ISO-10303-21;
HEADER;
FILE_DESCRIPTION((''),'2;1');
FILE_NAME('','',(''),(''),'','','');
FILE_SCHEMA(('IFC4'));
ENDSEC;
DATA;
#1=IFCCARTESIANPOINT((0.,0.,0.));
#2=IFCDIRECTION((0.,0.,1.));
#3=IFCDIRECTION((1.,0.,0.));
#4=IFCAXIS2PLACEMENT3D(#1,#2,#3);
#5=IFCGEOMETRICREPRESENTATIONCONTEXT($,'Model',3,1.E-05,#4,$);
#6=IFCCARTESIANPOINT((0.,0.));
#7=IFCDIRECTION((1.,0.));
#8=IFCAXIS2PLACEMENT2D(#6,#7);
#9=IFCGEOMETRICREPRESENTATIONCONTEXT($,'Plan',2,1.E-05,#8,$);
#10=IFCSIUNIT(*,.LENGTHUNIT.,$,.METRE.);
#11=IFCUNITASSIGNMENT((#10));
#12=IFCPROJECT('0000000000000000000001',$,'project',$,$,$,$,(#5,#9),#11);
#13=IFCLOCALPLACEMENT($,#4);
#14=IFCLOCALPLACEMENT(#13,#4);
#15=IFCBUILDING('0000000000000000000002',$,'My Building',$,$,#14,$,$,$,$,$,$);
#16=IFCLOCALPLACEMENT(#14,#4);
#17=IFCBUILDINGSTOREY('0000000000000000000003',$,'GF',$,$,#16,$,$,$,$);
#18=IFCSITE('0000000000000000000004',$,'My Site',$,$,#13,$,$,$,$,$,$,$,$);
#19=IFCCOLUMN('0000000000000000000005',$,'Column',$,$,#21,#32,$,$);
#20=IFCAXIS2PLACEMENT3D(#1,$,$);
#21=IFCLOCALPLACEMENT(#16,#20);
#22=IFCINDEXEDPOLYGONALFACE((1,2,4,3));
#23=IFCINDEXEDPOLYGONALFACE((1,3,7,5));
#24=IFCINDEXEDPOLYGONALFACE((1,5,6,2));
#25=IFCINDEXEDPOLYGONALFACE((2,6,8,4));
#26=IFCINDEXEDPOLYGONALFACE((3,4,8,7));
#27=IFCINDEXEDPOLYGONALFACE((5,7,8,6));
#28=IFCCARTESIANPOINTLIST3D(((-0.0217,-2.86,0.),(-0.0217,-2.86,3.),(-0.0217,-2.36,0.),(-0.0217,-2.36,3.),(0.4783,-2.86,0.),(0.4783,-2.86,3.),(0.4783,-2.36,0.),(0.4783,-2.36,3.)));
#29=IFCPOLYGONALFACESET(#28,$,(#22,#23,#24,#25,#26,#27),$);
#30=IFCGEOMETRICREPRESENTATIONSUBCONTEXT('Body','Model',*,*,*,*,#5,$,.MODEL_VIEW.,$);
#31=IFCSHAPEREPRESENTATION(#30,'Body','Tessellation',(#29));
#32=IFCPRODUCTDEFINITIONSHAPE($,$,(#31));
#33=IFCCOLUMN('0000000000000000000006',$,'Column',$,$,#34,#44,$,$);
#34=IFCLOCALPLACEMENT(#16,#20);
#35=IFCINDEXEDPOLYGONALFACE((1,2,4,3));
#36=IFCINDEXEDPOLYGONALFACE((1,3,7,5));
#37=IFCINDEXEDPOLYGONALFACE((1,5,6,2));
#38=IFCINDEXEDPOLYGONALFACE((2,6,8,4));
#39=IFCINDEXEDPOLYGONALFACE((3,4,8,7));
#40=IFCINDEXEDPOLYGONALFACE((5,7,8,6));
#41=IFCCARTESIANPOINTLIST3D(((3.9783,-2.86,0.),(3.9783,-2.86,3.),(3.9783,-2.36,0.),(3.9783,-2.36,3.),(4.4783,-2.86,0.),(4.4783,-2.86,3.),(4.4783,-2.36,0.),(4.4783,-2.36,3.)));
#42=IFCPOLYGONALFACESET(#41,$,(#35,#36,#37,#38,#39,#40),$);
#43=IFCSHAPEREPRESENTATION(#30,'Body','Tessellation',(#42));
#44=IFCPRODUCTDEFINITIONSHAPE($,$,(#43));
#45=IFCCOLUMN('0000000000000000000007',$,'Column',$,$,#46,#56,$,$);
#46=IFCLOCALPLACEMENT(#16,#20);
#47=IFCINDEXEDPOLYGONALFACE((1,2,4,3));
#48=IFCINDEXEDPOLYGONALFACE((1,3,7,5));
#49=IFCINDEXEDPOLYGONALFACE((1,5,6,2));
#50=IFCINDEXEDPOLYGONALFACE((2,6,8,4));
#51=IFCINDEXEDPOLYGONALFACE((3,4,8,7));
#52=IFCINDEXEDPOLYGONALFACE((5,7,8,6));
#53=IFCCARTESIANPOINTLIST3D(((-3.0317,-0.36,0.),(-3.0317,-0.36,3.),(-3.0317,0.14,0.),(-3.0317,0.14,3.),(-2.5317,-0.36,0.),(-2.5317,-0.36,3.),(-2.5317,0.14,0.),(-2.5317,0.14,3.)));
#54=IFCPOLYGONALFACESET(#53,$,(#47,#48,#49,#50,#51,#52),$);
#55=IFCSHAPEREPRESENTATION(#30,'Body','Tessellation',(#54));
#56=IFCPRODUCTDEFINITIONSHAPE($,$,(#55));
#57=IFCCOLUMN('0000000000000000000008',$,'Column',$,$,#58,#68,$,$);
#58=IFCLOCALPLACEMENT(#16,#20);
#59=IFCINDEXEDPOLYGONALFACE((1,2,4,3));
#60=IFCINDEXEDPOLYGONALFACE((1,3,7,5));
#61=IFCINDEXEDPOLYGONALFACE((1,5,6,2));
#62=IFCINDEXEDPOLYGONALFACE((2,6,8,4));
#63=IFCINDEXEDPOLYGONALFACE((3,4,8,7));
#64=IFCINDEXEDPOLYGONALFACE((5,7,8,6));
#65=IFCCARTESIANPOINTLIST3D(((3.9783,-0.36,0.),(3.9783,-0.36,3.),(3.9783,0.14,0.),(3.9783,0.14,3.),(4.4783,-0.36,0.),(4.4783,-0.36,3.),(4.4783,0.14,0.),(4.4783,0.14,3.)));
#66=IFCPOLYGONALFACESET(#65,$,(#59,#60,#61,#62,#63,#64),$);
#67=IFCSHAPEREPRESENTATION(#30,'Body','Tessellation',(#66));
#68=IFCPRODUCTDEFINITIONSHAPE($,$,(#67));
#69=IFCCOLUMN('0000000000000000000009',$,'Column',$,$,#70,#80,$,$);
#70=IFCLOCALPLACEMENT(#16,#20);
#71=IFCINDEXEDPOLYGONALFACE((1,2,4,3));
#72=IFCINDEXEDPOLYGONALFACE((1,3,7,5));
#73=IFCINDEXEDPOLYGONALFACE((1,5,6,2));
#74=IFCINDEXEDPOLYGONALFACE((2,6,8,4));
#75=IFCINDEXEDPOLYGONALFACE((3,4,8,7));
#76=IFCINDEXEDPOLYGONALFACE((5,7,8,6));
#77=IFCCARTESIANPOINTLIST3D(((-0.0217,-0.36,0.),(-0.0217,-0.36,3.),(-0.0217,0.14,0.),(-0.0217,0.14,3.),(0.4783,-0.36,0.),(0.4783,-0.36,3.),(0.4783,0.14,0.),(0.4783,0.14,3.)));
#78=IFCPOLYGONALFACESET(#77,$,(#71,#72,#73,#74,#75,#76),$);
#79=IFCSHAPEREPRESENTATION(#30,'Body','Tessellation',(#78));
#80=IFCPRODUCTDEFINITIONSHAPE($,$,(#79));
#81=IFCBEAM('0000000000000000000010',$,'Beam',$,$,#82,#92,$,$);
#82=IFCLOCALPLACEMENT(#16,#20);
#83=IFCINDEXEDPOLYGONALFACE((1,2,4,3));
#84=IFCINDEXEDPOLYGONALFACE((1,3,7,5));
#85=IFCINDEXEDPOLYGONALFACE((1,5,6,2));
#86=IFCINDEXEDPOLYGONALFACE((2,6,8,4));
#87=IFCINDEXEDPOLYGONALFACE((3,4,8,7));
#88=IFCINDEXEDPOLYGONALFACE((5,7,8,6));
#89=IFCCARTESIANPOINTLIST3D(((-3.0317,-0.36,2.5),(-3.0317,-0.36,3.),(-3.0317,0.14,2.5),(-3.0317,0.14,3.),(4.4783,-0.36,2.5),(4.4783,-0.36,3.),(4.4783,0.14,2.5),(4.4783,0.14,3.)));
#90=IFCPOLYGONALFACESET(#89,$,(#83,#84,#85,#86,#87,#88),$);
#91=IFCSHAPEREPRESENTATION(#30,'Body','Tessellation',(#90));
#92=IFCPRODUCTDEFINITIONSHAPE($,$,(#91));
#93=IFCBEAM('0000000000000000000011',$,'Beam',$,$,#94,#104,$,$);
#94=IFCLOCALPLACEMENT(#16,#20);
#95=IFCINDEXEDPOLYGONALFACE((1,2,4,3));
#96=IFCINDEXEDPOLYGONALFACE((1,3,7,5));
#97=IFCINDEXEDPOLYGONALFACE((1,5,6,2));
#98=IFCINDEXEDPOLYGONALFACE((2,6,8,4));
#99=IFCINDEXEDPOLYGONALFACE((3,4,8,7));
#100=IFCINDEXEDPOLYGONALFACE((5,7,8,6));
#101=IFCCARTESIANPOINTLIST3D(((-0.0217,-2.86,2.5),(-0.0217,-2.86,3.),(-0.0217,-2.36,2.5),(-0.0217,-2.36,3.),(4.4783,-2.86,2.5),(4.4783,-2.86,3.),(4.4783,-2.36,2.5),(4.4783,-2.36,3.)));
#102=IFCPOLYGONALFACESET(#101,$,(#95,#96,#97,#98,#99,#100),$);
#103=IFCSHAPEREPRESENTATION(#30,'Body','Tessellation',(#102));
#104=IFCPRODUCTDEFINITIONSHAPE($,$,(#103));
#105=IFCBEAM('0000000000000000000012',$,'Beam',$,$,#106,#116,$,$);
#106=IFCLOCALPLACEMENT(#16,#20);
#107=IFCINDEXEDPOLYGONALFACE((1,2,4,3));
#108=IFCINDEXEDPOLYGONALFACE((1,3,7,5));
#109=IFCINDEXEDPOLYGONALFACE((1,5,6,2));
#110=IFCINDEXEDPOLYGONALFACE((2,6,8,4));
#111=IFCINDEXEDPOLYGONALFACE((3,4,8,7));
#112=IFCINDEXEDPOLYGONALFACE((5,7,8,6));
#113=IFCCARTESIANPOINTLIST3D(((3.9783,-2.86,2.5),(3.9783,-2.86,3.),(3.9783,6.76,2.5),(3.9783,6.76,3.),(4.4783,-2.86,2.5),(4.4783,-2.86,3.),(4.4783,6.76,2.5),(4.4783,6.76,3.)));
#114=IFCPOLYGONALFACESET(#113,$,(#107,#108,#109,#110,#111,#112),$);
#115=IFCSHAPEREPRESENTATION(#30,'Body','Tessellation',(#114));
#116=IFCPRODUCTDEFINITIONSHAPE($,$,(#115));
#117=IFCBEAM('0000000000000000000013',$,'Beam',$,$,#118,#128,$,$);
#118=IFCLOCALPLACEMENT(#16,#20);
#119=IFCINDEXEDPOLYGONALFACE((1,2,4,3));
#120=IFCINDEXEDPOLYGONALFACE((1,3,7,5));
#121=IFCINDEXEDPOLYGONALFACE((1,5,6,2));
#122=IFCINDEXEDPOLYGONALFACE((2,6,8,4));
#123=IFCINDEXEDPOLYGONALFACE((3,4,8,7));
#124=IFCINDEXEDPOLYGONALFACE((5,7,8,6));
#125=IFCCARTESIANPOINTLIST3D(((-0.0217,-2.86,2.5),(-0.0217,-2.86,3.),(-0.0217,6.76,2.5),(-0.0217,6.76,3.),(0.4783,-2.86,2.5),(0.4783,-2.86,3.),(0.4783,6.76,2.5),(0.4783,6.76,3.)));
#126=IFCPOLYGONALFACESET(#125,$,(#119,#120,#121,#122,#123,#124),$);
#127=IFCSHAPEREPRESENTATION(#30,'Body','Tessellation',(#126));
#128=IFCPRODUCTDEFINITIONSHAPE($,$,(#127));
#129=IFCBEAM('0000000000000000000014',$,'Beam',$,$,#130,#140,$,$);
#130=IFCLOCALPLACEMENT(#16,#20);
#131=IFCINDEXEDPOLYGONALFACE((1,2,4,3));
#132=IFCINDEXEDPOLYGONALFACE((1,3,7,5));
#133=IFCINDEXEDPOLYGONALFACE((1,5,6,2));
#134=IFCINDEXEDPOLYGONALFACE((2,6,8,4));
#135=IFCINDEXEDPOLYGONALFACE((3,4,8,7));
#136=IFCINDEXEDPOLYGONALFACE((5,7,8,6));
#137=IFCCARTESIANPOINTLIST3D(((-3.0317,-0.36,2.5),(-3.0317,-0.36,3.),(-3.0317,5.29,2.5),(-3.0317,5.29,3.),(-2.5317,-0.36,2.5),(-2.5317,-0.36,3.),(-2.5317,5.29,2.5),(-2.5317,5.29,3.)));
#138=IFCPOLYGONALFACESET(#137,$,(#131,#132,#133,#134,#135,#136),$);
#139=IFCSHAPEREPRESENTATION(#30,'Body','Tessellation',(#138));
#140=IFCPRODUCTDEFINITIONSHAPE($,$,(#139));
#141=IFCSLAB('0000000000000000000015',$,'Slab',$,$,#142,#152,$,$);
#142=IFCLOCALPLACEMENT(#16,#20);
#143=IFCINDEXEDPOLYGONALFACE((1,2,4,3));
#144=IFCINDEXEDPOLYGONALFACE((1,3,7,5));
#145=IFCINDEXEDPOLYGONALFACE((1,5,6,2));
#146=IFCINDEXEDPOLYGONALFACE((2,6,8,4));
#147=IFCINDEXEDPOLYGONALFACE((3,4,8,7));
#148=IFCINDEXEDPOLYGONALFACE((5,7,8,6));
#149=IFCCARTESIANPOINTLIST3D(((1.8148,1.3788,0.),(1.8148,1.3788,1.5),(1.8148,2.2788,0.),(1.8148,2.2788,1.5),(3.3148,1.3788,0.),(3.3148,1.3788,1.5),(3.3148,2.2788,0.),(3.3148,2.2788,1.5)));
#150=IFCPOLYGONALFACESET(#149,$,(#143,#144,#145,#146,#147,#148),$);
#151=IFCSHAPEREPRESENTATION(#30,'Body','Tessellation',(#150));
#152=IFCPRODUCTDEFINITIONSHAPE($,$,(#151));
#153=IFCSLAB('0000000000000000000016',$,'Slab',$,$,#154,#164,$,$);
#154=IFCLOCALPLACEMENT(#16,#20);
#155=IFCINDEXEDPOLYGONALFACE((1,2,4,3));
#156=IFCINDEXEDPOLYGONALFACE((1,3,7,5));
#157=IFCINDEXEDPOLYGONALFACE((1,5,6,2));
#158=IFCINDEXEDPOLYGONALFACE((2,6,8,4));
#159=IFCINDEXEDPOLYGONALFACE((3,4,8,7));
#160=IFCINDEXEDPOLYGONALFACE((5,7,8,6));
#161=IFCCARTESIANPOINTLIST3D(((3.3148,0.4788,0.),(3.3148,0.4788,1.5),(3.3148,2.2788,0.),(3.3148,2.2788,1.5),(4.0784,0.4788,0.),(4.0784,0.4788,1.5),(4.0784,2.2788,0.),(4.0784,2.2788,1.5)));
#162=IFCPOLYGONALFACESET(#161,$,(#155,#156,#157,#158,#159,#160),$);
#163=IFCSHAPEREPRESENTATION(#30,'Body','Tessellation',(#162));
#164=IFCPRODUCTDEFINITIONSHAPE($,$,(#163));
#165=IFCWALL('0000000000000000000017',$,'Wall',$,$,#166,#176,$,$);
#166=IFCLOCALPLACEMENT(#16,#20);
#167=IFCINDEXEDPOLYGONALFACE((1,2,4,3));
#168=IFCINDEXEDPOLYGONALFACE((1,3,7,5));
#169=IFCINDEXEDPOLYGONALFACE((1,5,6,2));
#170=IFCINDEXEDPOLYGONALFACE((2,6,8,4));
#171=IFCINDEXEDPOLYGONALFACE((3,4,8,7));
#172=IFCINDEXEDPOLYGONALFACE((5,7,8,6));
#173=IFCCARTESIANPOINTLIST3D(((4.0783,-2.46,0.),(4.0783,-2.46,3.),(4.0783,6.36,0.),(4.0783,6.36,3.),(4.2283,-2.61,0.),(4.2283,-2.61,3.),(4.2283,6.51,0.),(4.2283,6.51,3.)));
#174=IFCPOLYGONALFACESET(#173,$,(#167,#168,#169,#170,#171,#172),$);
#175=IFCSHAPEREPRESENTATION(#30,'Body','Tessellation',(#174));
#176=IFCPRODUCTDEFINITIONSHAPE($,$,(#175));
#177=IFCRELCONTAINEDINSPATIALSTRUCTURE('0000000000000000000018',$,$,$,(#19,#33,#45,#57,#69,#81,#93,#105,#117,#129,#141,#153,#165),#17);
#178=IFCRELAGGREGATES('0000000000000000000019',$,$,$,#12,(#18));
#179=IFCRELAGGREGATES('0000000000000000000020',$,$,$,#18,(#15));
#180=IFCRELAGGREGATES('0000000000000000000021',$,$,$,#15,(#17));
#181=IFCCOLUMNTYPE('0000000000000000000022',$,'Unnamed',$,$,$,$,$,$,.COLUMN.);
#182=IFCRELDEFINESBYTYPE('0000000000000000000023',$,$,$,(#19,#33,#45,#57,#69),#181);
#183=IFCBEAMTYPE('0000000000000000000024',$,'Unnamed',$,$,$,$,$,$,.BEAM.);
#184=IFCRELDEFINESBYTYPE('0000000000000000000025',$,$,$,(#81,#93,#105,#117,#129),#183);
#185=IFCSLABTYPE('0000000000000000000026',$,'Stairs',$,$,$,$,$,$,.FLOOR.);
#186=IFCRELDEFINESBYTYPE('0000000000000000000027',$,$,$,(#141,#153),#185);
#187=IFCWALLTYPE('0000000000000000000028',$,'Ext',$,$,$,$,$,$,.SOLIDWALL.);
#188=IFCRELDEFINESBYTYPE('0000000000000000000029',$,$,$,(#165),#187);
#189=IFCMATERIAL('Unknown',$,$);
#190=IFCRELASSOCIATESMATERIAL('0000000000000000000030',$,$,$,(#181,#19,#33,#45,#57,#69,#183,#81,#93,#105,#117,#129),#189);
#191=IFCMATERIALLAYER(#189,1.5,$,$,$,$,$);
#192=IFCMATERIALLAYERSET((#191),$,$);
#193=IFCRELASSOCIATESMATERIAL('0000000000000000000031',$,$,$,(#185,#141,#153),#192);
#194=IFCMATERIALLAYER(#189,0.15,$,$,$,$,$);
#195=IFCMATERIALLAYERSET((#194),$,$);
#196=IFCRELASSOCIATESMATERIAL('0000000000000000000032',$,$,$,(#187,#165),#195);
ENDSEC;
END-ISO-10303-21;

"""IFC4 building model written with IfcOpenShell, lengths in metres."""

from ifc_helpers import new_model, si_unit, frame, origin_with_axes, origin_2d_with_axis, place, context, subcontext, project, spatial, line, indexed_curve, rectangle, outline, extrude, material, layer, layer_set, layer_usage, material_profile, profile_set, profile_usage, type_object, element, save


model = new_model("IFC4")

# Units and contexts
model_context = context("Model", 3, precision=1e-05, world=origin_with_axes())
plan_context = context("Plan", 2, precision=1e-05, world=origin_2d_with_axis())
body_context_1 = subcontext(model_context, "Body", "Model", "MODEL_VIEW")
ifc_project = project(units=[si_unit("LENGTHUNIT", "METRE")], contexts=[model_context, plan_context])

# Site, building, storey
site_placement = place(None, origin_with_axes())
site = spatial("IfcSite", under=ifc_project, at=site_placement, Name="My Site")
building_placement = place(site_placement, origin_with_axes())
building = spatial("IfcBuilding", under=site, at=building_placement, Name="My Building")
storey_placement = place(building_placement, origin_with_axes())
storey = spatial("IfcBuildingStorey", under=building, at=storey_placement, Name="GF")

# Columns
ifc_material = material(Name="Unknown")
ifc_material_profile_1 = material_profile(ifc_material, rectangle(XDim=0.5, YDim=0.5))
ifc_profile_set_1 = profile_set([ifc_material_profile_1])
ifc_profile_usage_1 = profile_usage(ifc_profile_set_1, cardinal=5)
column_type = type_object("IfcColumnType", Name="Unnamed", PredefinedType="COLUMN", material=ifc_profile_set_1)
column_1_placement = place(storey_placement, frame((0.2283, -2.61, 0.0), z_axis=(0.0, 0.0, 1.0), x_axis=(1.0, 0.0, 0.0)))
element("IfcColumn", 1, at=column_1_placement, inside=storey, type_object=column_type, material=ifc_profile_usage_1, Name="Column", context=body_context_1, shape_type="SweptSolid", body=[
    extrude(rectangle(XDim=0.5, YDim=0.5), origin_with_axes(), (0.0, 0.0, 1.0), 3.0),
])
ifc_profile_usage_2 = profile_usage(ifc_profile_set_1, cardinal=5)
column_2_placement = place(storey_placement, frame((4.2283, -2.61, 0.0), z_axis=(0.0, 0.0, 1.0), x_axis=(1.0, 0.0, 0.0)))
element("IfcColumn", 2, at=column_2_placement, inside=storey, type_object=column_type, material=ifc_profile_usage_2, Name="Column", context=body_context_1, shape_type="SweptSolid", body=[
    extrude(rectangle(XDim=0.5, YDim=0.5), origin_with_axes(), (0.0, 0.0, 1.0), 3.0),
])
ifc_profile_usage_3 = profile_usage(ifc_profile_set_1, cardinal=5)
column_3_placement = place(storey_placement, frame((-2.7817, -0.11, 0.0), z_axis=(0.0, 0.0, 1.0), x_axis=(1.0, 0.0, 0.0)))
element("IfcColumn", 3, at=column_3_placement, inside=storey, type_object=column_type, material=ifc_profile_usage_3, Name="Column", context=body_context_1, shape_type="SweptSolid", body=[
    extrude(rectangle(XDim=0.5, YDim=0.5), origin_with_axes(), (0.0, 0.0, 1.0), 3.0),
])
ifc_profile_usage_4 = profile_usage(ifc_profile_set_1, cardinal=5)
column_4_placement = place(storey_placement, frame((4.2283, -0.11, 0.0), z_axis=(0.0, 0.0, 1.0), x_axis=(1.0, 0.0, 0.0)))
element("IfcColumn", 4, at=column_4_placement, inside=storey, type_object=column_type, material=ifc_profile_usage_4, Name="Column", context=body_context_1, shape_type="SweptSolid", body=[
    extrude(rectangle(XDim=0.5, YDim=0.5), origin_with_axes(), (0.0, 0.0, 1.0), 3.0),
])
ifc_profile_usage_5 = profile_usage(ifc_profile_set_1, cardinal=5)
column_5_placement = place(storey_placement, frame((0.2283, -0.11, 0.0), z_axis=(0.0, 0.0, 1.0), x_axis=(1.0, 0.0, 0.0)))
element("IfcColumn", 5, at=column_5_placement, inside=storey, type_object=column_type, material=ifc_profile_usage_5, Name="Column", context=body_context_1, shape_type="SweptSolid", body=[
    extrude(rectangle(XDim=0.5, YDim=0.5), origin_with_axes(), (0.0, 0.0, 1.0), 3.0),
])

# Beams
ifc_material_profile_2 = material_profile(ifc_material, rectangle(XDim=0.5, YDim=0.5))
ifc_profile_set_2 = profile_set([ifc_material_profile_2])
ifc_profile_usage_6 = profile_usage(ifc_profile_set_2, cardinal=9)
beam_type = type_object("IfcBeamType", Name="Unnamed", PredefinedType="BEAM", material=ifc_profile_set_2)
beam_1_placement = place(storey_placement, frame((4.4783, 0.14, 3.0), z_axis=(-1.0, 0.0, 0.0), x_axis=(0.0, -1.0, 0.0)))
element("IfcBeam", 6, at=beam_1_placement, inside=storey, type_object=beam_type, material=ifc_profile_usage_6, Name="Beam", context=body_context_1, shape_type="SweptSolid", body=[
    extrude(rectangle(XDim=0.5, YDim=0.5), frame((0.25, -0.25, 0.0), z_axis=(0.0, 0.0, 1.0), x_axis=(1.0, 0.0, 0.0)), (0.0, 0.0, 1.0), 7.51),
])
ifc_profile_usage_7 = profile_usage(ifc_profile_set_2, cardinal=9)
beam_2_placement = place(storey_placement, frame((4.4783, -2.36, 3.0), z_axis=(-1.0, 0.0, 0.0), x_axis=(0.0, -1.0, 0.0)))
element("IfcBeam", 7, at=beam_2_placement, inside=storey, type_object=beam_type, material=ifc_profile_usage_7, Name="Beam", context=body_context_1, shape_type="SweptSolid", body=[
    extrude(rectangle(XDim=0.5, YDim=0.5), frame((0.25, -0.25, 0.0), z_axis=(0.0, 0.0, 1.0), x_axis=(1.0, 0.0, 0.0)), (0.0, 0.0, 1.0), 4.5),
])
ifc_profile_usage_8 = profile_usage(ifc_profile_set_2, cardinal=9)
beam_3_placement = place(storey_placement, frame((4.4783, -2.86, 3.0), z_axis=(0.0, 1.0, 0.0), x_axis=(-1.0, 0.0, 0.0)))
element("IfcBeam", 8, at=beam_3_placement, inside=storey, type_object=beam_type, material=ifc_profile_usage_8, Name="Beam", context=body_context_1, shape_type="SweptSolid", body=[
    extrude(rectangle(XDim=0.5, YDim=0.5), frame((0.25, -0.25, 0.0), z_axis=(0.0, 0.0, 1.0), x_axis=(1.0, 0.0, 0.0)), (0.0, 0.0, 1.0), 9.62),
])
ifc_profile_usage_9 = profile_usage(ifc_profile_set_2, cardinal=9)
beam_4_placement = place(storey_placement, frame((0.4783, -2.86, 3.0), z_axis=(0.0, 1.0, 0.0), x_axis=(-1.0, 0.0, 0.0)))
element("IfcBeam", 9, at=beam_4_placement, inside=storey, type_object=beam_type, material=ifc_profile_usage_9, Name="Beam", context=body_context_1, shape_type="SweptSolid", body=[
    extrude(rectangle(XDim=0.5, YDim=0.5), frame((0.25, -0.25, 0.0), z_axis=(0.0, 0.0, 1.0), x_axis=(1.0, 0.0, 0.0)), (0.0, 0.0, 1.0), 9.62),
])
ifc_profile_usage_10 = profile_usage(ifc_profile_set_2, cardinal=9)
beam_5_placement = place(storey_placement, frame((-2.5317, -0.36, 3.0), z_axis=(0.0, 1.0, 0.0), x_axis=(-1.0, 0.0, 0.0)))
element("IfcBeam", 10, at=beam_5_placement, inside=storey, type_object=beam_type, material=ifc_profile_usage_10, Name="Beam", context=body_context_1, shape_type="SweptSolid", body=[
    extrude(rectangle(XDim=0.5, YDim=0.5), frame((0.25, -0.25, 0.0), z_axis=(0.0, 0.0, 1.0), x_axis=(1.0, 0.0, 0.0)), (0.0, 0.0, 1.0), 5.65),
])

# Slabs
ifc_layer_1 = layer(ifc_material, 1.5)
ifc_layer_set_1 = layer_set([ifc_layer_1])
ifc_layer_usage_1 = layer_usage(ifc_layer_set_1, "AXIS3", "POSITIVE", -1.5)
slab_type = type_object("IfcSlabType", Name="Stairs", PredefinedType="FLOOR", material=ifc_layer_set_1)
slab_1_placement = place(storey_placement, frame((3.3148, 2.2788, 1.5), z_axis=(0.0, 0.0, 1.0), x_axis=(1.0, 0.0, 0.0)))
element("IfcSlab", 11, at=slab_1_placement, inside=storey, type_object=slab_type, material=ifc_layer_usage_1, Name="Slab", context=body_context_1, shape_type="SweptSolid", body=[
    extrude(outline(indexed_curve([(0.0, 0.0), (0.0, -0.9), (-1.5, -0.9), (-1.5, 0.0), (0.0, 0.0)])), frame((0.0, 0.0, -1.5), z_axis=(0.0, 0.0, 1.0), x_axis=(1.0, 0.0, 0.0)), (0.0, 0.0, 1.0), 1.5),
])
ifc_layer_usage_2 = layer_usage(ifc_layer_set_1, "AXIS3", "POSITIVE", -1.5)
slab_2_placement = place(storey_placement, frame((3.3148, 0.4788, 1.5), z_axis=(0.0, 0.0, 1.0), x_axis=(1.0, 0.0, 0.0)))
element("IfcSlab", 12, at=slab_2_placement, inside=storey, type_object=slab_type, material=ifc_layer_usage_2, Name="Slab", context=body_context_1, shape_type="SweptSolid", body=[
    extrude(outline(indexed_curve([(0.0, 0.0), (0.7636, 0.0), (0.7636, 1.8), (0.0, 1.8), (0.0, 0.0)])), frame((0.0, 0.0, -1.5), z_axis=(0.0, 0.0, 1.0), x_axis=(1.0, 0.0, 0.0)), (0.0, 0.0, 1.0), 1.5),
])

# Shared definitions
ifc_layer_2 = layer(ifc_material, 0.15)
ifc_layer_set_2 = layer_set([ifc_layer_2])
wall_type_1 = type_object("IfcWallType", Name="Ext", PredefinedType="SOLIDWALL", material=ifc_layer_set_2)

# Wall
ifc_layer_usage_3 = layer_usage(ifc_layer_set_2, "AXIS2", "POSITIVE", 0.0)
wall_1_placement = place(storey_placement, frame((4.2283, -2.61, 0.0), z_axis=(0.0, 0.0, 1.0), x_axis=(0.0, 1.0, 0.0)))
element("IfcWall", 13, at=wall_1_placement, inside=storey, type_object=wall_type_1, material=ifc_layer_usage_3, Name="Wall", context=body_context_1, shape_type="SweptSolid", body=[
    extrude(outline(indexed_curve([(0.0, 0.0), (0.15, 0.15), (8.97, 0.15), (9.12, 0.0)], segments=[line(1, 2, 3, 4, 1)])), origin_with_axes(), (0.0, 0.0, 1.0), 3.0),
])

save(model, "model.ifc")
